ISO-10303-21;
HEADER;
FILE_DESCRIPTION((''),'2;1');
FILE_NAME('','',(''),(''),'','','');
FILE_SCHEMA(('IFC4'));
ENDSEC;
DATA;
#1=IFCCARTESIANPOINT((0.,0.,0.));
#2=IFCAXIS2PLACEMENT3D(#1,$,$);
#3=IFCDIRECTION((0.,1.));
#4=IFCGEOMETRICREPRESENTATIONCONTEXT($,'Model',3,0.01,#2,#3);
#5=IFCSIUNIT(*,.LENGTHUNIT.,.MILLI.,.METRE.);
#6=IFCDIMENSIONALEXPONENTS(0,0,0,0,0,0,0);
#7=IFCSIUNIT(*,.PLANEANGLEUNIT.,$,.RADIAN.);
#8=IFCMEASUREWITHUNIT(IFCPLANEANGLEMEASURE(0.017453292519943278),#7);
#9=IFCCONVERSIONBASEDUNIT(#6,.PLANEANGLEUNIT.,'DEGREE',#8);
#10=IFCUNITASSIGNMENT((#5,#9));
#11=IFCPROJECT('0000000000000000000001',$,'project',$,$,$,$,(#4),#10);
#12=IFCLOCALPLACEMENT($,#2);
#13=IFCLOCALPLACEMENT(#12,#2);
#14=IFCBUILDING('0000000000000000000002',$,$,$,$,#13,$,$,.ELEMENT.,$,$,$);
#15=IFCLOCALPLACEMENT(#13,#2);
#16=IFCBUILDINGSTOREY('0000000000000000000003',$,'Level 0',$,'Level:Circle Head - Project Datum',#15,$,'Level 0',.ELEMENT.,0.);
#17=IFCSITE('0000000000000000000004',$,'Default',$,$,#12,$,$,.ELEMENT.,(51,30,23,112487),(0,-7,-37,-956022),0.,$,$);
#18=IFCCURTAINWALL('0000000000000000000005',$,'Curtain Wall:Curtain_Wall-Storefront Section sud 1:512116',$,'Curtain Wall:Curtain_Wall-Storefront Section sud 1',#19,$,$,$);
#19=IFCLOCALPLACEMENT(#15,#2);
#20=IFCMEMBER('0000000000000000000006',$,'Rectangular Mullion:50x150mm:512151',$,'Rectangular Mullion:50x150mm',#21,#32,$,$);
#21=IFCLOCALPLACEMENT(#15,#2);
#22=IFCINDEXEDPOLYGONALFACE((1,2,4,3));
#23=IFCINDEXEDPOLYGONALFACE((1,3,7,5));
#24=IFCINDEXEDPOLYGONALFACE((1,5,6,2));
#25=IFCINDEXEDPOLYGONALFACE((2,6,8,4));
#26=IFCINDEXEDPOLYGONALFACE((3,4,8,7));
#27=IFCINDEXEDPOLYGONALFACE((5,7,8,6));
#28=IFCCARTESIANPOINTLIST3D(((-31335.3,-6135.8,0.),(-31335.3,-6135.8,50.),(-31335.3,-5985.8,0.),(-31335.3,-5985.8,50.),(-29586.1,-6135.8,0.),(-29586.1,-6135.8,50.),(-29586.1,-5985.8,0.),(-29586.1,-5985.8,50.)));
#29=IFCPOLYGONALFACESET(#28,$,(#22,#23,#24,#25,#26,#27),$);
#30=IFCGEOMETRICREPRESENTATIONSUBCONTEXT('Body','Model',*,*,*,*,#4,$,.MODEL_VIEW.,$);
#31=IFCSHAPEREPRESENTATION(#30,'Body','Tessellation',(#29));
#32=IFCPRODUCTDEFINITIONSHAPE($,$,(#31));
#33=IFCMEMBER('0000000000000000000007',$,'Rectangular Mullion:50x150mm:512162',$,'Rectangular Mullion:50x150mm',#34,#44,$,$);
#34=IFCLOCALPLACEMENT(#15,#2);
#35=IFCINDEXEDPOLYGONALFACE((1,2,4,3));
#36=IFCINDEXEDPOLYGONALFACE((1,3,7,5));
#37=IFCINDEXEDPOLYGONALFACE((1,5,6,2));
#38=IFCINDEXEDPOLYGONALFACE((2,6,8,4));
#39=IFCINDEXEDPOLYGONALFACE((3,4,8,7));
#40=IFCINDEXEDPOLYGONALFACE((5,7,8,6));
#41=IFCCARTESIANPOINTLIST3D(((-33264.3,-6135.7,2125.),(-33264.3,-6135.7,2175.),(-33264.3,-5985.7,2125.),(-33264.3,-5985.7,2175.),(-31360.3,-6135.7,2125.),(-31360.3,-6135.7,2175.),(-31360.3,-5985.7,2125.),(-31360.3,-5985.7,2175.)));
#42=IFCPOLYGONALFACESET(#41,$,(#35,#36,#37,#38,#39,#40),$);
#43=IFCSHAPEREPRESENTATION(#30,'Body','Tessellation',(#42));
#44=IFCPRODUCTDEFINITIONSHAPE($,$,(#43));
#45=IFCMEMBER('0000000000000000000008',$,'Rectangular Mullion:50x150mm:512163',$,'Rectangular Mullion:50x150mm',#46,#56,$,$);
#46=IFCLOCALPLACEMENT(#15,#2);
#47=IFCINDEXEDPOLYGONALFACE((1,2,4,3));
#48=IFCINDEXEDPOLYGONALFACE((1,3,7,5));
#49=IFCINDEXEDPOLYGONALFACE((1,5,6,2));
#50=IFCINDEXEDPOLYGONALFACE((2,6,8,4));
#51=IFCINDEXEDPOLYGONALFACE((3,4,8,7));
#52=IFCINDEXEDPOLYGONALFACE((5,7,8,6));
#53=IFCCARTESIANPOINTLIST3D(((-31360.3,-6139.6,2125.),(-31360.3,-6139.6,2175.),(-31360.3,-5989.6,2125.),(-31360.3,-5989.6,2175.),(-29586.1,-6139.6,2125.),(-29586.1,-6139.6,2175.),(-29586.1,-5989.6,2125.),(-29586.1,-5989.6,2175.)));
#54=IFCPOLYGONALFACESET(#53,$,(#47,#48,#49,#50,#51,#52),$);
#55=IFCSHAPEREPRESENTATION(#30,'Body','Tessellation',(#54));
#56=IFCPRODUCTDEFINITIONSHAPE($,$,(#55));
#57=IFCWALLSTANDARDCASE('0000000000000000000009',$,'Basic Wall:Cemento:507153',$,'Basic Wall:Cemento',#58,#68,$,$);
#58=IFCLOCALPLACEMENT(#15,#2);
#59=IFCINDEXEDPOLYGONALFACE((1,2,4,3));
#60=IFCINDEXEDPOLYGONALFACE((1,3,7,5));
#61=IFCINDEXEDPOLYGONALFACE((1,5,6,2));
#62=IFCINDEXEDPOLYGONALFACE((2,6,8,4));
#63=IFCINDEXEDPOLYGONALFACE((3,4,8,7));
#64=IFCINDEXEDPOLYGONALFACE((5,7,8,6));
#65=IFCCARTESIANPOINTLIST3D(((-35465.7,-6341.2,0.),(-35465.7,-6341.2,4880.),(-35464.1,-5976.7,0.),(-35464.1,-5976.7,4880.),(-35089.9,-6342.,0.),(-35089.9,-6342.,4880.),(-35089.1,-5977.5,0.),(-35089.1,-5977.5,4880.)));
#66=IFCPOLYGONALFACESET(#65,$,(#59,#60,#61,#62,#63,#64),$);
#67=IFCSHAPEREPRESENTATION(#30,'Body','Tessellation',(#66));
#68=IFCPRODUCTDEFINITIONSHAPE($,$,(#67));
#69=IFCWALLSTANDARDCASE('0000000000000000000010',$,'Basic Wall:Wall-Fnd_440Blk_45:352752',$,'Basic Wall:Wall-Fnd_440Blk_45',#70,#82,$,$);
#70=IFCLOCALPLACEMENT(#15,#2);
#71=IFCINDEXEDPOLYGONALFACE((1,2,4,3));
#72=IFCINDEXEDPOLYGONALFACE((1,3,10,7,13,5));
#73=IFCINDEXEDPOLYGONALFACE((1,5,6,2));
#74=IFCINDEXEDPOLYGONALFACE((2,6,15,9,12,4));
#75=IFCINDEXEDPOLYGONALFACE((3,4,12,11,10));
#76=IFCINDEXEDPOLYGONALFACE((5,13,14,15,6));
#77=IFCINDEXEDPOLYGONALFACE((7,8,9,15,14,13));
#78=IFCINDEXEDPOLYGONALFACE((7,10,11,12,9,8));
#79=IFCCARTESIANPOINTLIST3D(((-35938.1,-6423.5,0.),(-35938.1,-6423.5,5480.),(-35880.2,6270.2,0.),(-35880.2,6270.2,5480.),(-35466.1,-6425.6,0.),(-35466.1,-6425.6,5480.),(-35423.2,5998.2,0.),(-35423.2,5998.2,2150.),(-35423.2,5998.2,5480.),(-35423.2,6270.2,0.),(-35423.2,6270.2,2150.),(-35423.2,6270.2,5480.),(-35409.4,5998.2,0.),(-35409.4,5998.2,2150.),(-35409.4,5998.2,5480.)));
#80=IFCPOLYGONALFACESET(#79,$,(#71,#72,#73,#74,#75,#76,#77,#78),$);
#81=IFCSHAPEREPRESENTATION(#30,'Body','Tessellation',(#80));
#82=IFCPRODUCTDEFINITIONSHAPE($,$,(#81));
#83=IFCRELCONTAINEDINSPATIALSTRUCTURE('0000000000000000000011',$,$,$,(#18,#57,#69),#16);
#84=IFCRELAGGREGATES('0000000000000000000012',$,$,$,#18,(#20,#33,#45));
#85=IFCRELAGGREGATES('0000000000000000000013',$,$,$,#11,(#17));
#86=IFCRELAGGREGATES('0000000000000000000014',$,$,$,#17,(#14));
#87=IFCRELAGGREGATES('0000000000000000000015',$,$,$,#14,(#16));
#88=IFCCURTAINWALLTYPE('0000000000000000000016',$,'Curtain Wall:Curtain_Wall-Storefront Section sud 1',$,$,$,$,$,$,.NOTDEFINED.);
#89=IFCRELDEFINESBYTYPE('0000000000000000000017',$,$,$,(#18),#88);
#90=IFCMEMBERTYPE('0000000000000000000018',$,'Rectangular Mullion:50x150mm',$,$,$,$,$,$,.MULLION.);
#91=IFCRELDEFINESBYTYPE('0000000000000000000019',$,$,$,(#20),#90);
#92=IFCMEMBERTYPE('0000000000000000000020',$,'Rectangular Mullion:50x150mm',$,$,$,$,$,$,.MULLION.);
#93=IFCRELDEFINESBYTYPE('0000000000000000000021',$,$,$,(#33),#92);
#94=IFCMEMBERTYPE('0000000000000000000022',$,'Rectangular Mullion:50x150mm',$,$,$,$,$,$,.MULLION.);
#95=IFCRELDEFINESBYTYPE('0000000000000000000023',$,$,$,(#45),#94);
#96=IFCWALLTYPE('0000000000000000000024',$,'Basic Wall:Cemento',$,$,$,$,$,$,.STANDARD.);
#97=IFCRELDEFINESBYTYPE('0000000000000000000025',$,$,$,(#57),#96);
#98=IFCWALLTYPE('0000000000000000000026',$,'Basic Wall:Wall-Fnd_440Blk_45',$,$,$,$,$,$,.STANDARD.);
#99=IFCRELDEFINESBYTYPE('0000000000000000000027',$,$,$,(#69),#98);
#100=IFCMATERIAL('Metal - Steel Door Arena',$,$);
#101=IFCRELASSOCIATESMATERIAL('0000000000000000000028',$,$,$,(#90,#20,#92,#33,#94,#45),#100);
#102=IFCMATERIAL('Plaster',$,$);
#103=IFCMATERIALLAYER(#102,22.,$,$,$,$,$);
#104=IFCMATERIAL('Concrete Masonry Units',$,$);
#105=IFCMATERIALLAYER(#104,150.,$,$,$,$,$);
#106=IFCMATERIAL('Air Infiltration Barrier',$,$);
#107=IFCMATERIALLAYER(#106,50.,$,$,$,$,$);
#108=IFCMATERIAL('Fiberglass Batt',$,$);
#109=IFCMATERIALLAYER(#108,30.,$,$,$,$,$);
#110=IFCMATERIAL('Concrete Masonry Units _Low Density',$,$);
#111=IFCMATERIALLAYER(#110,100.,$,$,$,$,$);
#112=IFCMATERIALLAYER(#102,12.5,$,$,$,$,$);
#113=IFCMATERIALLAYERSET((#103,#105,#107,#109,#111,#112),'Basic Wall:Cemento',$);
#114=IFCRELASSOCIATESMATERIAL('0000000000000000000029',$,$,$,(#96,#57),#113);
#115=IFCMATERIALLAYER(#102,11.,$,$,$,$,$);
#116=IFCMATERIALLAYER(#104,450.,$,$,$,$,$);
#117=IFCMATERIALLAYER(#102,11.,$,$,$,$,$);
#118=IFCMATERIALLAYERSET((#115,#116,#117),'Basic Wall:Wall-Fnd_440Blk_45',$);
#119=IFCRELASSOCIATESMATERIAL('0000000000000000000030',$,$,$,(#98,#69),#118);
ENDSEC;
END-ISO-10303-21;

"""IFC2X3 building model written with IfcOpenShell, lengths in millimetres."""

from ifc_helpers import new_model, entity, si_unit, converted_unit, direction, frame, frame_2d, origin, origin_2d_with_axis, place, context, subcontext, project, spatial, polyline, rectangle, outline, extrude, source, transform, mapped, material, layer, layer_set, layer_usage, type_object, type_shapes, element, aggregate, save


model = new_model("IFC2X3")

# Units and contexts
model_context = context("Model", 3, precision=0.01, world=origin(), true_north=direction((0.0, 1.0)))
body_context = subcontext(model_context, "Body", "Model", "MODEL_VIEW")
ifc_project = project(units=[si_unit("LENGTHUNIT", "METRE", prefix="MILLI"), converted_unit("PLANEANGLEUNIT", "DEGREE", entity("IfcPlaneAngleMeasure", 0.017453292519943278), si_unit("PLANEANGLEUNIT", "RADIAN"), dimensions=[0, 0, 0, 0, 0, 0, 0])], contexts=[model_context])

# Site, building, storey
site_placement = place(None, origin())
site = spatial("IfcSite", under=ifc_project, at=site_placement, Name="Default", CompositionType="ELEMENT", RefLatitude=(51, 30, 23, 112487), RefLongitude=(0, -7, -37, -956022), RefElevation=0.0)
building_placement = place(site_placement, origin())
building = spatial("IfcBuilding", under=site, at=building_placement, CompositionType="ELEMENT")
storey_placement = place(building_placement, origin())
storey = spatial("IfcBuildingStorey", under=building, at=storey_placement, Name="Level 0", ObjectType="Level:Circle Head - Project Datum", LongName="Level 0", CompositionType="ELEMENT", Elevation=0.0)

# Curtain wall, members
curtain_wall_type = type_object("IfcCurtainWallType", Name="Curtain Wall:Curtain_Wall-Storefront Section sud 1", PredefinedType="NOTDEFINED")
curtain_wall_placement = place(storey_placement, origin())
curtain_wall = element("IfcCurtainWall", 1, at=curtain_wall_placement, inside=storey, type_object=curtain_wall_type, Name="Curtain Wall:Curtain_Wall-Storefront Section sud 1:512116", ObjectType="Curtain Wall:Curtain_Wall-Storefront Section sud 1")
ifc_material_1 = material(Name="Metal - Steel Door Arena")
member_type_1 = type_object("IfcMemberType", Name="Rectangular Mullion:50x150mm", PredefinedType="MULLION", material=ifc_material_1)
shared_shape_1 = source(origin(), body_context, "Body", "SweptSolid", [
    extrude(rectangle(XDim=50.0, YDim=150.0, at=origin_2d_with_axis()), frame((-25.0, 0.0, -1749.2), z_axis=(0.0, 0.0, 1.0), x_axis=(-1.0, 0.0, 0.0)), (0.0, 0.0, 1.0), 1749.2),
])
type_shapes(member_type_1, [shared_shape_1])
member_1_placement = place(curtain_wall_placement, frame((-31335.3, -6060.8, 0.0), z_axis=(-1.0, 0.0, 0.0), x_axis=(0.0, 0.0, -1.0)))
member_1 = element("IfcMember", 2, at=member_1_placement, type_object=member_type_1, material=ifc_material_1, Name="Rectangular Mullion:50x150mm:512151", ObjectType="Rectangular Mullion:50x150mm", context=body_context, shape_type="MappedRepresentation", body=[
    mapped(shared_shape_1, transform((0.0, 0.0, 0.0), scale=1.0)),
])
member_type_2 = type_object("IfcMemberType", Name="Rectangular Mullion:50x150mm", PredefinedType="MULLION", material=ifc_material_1)
shared_shape_2 = source(origin(), body_context, "Body", "SweptSolid", [
    extrude(rectangle(XDim=50.0, YDim=150.0, at=origin_2d_with_axis()), frame((0.0, 0.0, -1904.0), z_axis=(0.0, 0.0, 1.0), x_axis=(-1.0, 0.0, 0.0)), (0.0, 0.0, 1.0), 1904.0),
])
type_shapes(member_type_2, [shared_shape_2])
member_2_placement = place(curtain_wall_placement, frame((-31360.3, -6060.7, 2150.0), z_axis=(1.0, 0.0, 0.0), x_axis=(0.0, 0.0, 1.0)))
member_2 = element("IfcMember", 3, at=member_2_placement, type_object=member_type_2, material=ifc_material_1, Name="Rectangular Mullion:50x150mm:512162", ObjectType="Rectangular Mullion:50x150mm", context=body_context, shape_type="MappedRepresentation", body=[
    mapped(shared_shape_2, transform((0.0, 0.0, 0.0), scale=1.0)),
])
member_type_3 = type_object("IfcMemberType", Name="Rectangular Mullion:50x150mm", PredefinedType="MULLION", material=ifc_material_1)
shared_shape_3 = source(origin(), body_context, "Body", "SweptSolid", [
    extrude(rectangle(XDim=50.0, YDim=150.0, at=origin_2d_with_axis()), frame((0.0, 0.0, -1774.2), z_axis=(0.0, 0.0, 1.0), x_axis=(-1.0, 0.0, 0.0)), (0.0, 0.0, 1.0), 1774.2),
])
type_shapes(member_type_3, [shared_shape_3])
member_3_placement = place(curtain_wall_placement, frame((-29586.1, -6064.6, 2150.0), z_axis=(1.0, 0.0, 0.0), x_axis=(0.0, 0.0, 1.0)))
member_3 = element("IfcMember", 4, at=member_3_placement, type_object=member_type_3, material=ifc_material_1, Name="Rectangular Mullion:50x150mm:512163", ObjectType="Rectangular Mullion:50x150mm", context=body_context, shape_type="MappedRepresentation", body=[
    mapped(shared_shape_3, transform((0.0, 0.0, 0.0), scale=1.0)),
])
aggregate(curtain_wall, [member_1, member_2, member_3])

# Wall
ifc_material_2 = material(Name="Plaster")
ifc_layer_1 = layer(ifc_material_2, 22.0)
ifc_material_3 = material(Name="Concrete Masonry Units")
ifc_layer_2 = layer(ifc_material_3, 150.0)
ifc_material_4 = material(Name="Air Infiltration Barrier")
ifc_layer_3 = layer(ifc_material_4, 50.0)
ifc_material_5 = material(Name="Fiberglass Batt")
ifc_layer_4 = layer(ifc_material_5, 30.0)
ifc_material_6 = material(Name="Concrete Masonry Units _Low Density")
ifc_layer_5 = layer(ifc_material_6, 100.0)
ifc_layer_6 = layer(ifc_material_2, 12.5)
ifc_layer_set_1 = layer_set([ifc_layer_1, ifc_layer_2, ifc_layer_3, ifc_layer_4, ifc_layer_5, ifc_layer_6], Name="Basic Wall:Cemento")
ifc_layer_usage_1 = layer_usage(ifc_layer_set_1, "AXIS2", "NEGATIVE", 182.3)
wall_type_1 = type_object("IfcWallType", Name="Basic Wall:Cemento", PredefinedType="STANDARD", material=ifc_layer_set_1)
wall_1_placement = place(storey_placement, frame((-35089.5, -6159.8, 0.0), z_axis=(0.0, 0.0, 1.0), x_axis=(-0.999998, 0.002199, 0.0)))
element("IfcWallStandardCase", 5, at=wall_1_placement, inside=storey, type_object=wall_type_1, material=ifc_layer_usage_1, Name="Basic Wall:Cemento:507153", ObjectType="Basic Wall:Cemento", context=body_context, shape_type="SweptSolid", body=[
    extrude(outline(polyline([(374.9, -182.2), (375.8, 182.3), (0.0, 182.3), (0.0, -182.2), (374.9, -182.2)])), origin(), (0.0, 0.0, 1.0), 4880.0),
])

# Wall, opening
ifc_layer_7 = layer(ifc_material_2, 11.0)
ifc_layer_8 = layer(ifc_material_3, 450.0)
ifc_layer_9 = layer(ifc_material_2, 11.0)
ifc_layer_set_2 = layer_set([ifc_layer_7, ifc_layer_8, ifc_layer_9], Name="Basic Wall:Wall-Fnd_440Blk_45")
ifc_layer_usage_2 = layer_usage(ifc_layer_set_2, "AXIS2", "NEGATIVE", 236.0)
wall_type_2 = type_object("IfcWallType", Name="Basic Wall:Wall-Fnd_440Blk_45", PredefinedType="STANDARD", material=ifc_layer_set_2)
wall_2_placement = place(storey_placement, frame((-35644.2, 6271.3, 0.0), z_axis=(0.0, 0.0, 1.0), x_axis=(-0.004561, -0.99999, 0.0)))
wall_2 = element("IfcWallStandardCase", 6, at=wall_2_placement, inside=storey, type_object=wall_type_2, material=ifc_layer_usage_2, Name="Basic Wall:Wall-Fnd_440Blk_45:352752", ObjectType="Basic Wall:Wall-Fnd_440Blk_45", context=body_context, shape_type="SweptSolid", body=[
    extrude(outline(polyline([(12696.0, -236.0), (12696.0, 236.0), (12611.6, 236.0), (12247.1, 236.0), (272.0, 236.0), (272.1, 222.2), (0.1, 221.0), (2.2, -236.0), (12696.0, -236.0)])), origin(), (0.0, 0.0, 1.0), 5480.0),
])
opening_placement = place(wall_2_placement, origin())
element("IfcOpeningElement", 7, at=opening_placement, cuts=wall_2, ObjectType="Opening", context=body_context, shape_type="SweptSolid", body=[
    extrude(rectangle(XDim=2150.0, YDim=272.0, at=frame_2d((0.0, 0.0), x_axis=(0.0, 1.0))), frame((136.1, 221.6, 1075.0), z_axis=(-0.004561, 0.99999, 0.0), x_axis=(-0.99999, -0.004561, 0.0)), (0.0, 0.0, 1.0), 1600.0),
])

save(model, "model.ifc")
